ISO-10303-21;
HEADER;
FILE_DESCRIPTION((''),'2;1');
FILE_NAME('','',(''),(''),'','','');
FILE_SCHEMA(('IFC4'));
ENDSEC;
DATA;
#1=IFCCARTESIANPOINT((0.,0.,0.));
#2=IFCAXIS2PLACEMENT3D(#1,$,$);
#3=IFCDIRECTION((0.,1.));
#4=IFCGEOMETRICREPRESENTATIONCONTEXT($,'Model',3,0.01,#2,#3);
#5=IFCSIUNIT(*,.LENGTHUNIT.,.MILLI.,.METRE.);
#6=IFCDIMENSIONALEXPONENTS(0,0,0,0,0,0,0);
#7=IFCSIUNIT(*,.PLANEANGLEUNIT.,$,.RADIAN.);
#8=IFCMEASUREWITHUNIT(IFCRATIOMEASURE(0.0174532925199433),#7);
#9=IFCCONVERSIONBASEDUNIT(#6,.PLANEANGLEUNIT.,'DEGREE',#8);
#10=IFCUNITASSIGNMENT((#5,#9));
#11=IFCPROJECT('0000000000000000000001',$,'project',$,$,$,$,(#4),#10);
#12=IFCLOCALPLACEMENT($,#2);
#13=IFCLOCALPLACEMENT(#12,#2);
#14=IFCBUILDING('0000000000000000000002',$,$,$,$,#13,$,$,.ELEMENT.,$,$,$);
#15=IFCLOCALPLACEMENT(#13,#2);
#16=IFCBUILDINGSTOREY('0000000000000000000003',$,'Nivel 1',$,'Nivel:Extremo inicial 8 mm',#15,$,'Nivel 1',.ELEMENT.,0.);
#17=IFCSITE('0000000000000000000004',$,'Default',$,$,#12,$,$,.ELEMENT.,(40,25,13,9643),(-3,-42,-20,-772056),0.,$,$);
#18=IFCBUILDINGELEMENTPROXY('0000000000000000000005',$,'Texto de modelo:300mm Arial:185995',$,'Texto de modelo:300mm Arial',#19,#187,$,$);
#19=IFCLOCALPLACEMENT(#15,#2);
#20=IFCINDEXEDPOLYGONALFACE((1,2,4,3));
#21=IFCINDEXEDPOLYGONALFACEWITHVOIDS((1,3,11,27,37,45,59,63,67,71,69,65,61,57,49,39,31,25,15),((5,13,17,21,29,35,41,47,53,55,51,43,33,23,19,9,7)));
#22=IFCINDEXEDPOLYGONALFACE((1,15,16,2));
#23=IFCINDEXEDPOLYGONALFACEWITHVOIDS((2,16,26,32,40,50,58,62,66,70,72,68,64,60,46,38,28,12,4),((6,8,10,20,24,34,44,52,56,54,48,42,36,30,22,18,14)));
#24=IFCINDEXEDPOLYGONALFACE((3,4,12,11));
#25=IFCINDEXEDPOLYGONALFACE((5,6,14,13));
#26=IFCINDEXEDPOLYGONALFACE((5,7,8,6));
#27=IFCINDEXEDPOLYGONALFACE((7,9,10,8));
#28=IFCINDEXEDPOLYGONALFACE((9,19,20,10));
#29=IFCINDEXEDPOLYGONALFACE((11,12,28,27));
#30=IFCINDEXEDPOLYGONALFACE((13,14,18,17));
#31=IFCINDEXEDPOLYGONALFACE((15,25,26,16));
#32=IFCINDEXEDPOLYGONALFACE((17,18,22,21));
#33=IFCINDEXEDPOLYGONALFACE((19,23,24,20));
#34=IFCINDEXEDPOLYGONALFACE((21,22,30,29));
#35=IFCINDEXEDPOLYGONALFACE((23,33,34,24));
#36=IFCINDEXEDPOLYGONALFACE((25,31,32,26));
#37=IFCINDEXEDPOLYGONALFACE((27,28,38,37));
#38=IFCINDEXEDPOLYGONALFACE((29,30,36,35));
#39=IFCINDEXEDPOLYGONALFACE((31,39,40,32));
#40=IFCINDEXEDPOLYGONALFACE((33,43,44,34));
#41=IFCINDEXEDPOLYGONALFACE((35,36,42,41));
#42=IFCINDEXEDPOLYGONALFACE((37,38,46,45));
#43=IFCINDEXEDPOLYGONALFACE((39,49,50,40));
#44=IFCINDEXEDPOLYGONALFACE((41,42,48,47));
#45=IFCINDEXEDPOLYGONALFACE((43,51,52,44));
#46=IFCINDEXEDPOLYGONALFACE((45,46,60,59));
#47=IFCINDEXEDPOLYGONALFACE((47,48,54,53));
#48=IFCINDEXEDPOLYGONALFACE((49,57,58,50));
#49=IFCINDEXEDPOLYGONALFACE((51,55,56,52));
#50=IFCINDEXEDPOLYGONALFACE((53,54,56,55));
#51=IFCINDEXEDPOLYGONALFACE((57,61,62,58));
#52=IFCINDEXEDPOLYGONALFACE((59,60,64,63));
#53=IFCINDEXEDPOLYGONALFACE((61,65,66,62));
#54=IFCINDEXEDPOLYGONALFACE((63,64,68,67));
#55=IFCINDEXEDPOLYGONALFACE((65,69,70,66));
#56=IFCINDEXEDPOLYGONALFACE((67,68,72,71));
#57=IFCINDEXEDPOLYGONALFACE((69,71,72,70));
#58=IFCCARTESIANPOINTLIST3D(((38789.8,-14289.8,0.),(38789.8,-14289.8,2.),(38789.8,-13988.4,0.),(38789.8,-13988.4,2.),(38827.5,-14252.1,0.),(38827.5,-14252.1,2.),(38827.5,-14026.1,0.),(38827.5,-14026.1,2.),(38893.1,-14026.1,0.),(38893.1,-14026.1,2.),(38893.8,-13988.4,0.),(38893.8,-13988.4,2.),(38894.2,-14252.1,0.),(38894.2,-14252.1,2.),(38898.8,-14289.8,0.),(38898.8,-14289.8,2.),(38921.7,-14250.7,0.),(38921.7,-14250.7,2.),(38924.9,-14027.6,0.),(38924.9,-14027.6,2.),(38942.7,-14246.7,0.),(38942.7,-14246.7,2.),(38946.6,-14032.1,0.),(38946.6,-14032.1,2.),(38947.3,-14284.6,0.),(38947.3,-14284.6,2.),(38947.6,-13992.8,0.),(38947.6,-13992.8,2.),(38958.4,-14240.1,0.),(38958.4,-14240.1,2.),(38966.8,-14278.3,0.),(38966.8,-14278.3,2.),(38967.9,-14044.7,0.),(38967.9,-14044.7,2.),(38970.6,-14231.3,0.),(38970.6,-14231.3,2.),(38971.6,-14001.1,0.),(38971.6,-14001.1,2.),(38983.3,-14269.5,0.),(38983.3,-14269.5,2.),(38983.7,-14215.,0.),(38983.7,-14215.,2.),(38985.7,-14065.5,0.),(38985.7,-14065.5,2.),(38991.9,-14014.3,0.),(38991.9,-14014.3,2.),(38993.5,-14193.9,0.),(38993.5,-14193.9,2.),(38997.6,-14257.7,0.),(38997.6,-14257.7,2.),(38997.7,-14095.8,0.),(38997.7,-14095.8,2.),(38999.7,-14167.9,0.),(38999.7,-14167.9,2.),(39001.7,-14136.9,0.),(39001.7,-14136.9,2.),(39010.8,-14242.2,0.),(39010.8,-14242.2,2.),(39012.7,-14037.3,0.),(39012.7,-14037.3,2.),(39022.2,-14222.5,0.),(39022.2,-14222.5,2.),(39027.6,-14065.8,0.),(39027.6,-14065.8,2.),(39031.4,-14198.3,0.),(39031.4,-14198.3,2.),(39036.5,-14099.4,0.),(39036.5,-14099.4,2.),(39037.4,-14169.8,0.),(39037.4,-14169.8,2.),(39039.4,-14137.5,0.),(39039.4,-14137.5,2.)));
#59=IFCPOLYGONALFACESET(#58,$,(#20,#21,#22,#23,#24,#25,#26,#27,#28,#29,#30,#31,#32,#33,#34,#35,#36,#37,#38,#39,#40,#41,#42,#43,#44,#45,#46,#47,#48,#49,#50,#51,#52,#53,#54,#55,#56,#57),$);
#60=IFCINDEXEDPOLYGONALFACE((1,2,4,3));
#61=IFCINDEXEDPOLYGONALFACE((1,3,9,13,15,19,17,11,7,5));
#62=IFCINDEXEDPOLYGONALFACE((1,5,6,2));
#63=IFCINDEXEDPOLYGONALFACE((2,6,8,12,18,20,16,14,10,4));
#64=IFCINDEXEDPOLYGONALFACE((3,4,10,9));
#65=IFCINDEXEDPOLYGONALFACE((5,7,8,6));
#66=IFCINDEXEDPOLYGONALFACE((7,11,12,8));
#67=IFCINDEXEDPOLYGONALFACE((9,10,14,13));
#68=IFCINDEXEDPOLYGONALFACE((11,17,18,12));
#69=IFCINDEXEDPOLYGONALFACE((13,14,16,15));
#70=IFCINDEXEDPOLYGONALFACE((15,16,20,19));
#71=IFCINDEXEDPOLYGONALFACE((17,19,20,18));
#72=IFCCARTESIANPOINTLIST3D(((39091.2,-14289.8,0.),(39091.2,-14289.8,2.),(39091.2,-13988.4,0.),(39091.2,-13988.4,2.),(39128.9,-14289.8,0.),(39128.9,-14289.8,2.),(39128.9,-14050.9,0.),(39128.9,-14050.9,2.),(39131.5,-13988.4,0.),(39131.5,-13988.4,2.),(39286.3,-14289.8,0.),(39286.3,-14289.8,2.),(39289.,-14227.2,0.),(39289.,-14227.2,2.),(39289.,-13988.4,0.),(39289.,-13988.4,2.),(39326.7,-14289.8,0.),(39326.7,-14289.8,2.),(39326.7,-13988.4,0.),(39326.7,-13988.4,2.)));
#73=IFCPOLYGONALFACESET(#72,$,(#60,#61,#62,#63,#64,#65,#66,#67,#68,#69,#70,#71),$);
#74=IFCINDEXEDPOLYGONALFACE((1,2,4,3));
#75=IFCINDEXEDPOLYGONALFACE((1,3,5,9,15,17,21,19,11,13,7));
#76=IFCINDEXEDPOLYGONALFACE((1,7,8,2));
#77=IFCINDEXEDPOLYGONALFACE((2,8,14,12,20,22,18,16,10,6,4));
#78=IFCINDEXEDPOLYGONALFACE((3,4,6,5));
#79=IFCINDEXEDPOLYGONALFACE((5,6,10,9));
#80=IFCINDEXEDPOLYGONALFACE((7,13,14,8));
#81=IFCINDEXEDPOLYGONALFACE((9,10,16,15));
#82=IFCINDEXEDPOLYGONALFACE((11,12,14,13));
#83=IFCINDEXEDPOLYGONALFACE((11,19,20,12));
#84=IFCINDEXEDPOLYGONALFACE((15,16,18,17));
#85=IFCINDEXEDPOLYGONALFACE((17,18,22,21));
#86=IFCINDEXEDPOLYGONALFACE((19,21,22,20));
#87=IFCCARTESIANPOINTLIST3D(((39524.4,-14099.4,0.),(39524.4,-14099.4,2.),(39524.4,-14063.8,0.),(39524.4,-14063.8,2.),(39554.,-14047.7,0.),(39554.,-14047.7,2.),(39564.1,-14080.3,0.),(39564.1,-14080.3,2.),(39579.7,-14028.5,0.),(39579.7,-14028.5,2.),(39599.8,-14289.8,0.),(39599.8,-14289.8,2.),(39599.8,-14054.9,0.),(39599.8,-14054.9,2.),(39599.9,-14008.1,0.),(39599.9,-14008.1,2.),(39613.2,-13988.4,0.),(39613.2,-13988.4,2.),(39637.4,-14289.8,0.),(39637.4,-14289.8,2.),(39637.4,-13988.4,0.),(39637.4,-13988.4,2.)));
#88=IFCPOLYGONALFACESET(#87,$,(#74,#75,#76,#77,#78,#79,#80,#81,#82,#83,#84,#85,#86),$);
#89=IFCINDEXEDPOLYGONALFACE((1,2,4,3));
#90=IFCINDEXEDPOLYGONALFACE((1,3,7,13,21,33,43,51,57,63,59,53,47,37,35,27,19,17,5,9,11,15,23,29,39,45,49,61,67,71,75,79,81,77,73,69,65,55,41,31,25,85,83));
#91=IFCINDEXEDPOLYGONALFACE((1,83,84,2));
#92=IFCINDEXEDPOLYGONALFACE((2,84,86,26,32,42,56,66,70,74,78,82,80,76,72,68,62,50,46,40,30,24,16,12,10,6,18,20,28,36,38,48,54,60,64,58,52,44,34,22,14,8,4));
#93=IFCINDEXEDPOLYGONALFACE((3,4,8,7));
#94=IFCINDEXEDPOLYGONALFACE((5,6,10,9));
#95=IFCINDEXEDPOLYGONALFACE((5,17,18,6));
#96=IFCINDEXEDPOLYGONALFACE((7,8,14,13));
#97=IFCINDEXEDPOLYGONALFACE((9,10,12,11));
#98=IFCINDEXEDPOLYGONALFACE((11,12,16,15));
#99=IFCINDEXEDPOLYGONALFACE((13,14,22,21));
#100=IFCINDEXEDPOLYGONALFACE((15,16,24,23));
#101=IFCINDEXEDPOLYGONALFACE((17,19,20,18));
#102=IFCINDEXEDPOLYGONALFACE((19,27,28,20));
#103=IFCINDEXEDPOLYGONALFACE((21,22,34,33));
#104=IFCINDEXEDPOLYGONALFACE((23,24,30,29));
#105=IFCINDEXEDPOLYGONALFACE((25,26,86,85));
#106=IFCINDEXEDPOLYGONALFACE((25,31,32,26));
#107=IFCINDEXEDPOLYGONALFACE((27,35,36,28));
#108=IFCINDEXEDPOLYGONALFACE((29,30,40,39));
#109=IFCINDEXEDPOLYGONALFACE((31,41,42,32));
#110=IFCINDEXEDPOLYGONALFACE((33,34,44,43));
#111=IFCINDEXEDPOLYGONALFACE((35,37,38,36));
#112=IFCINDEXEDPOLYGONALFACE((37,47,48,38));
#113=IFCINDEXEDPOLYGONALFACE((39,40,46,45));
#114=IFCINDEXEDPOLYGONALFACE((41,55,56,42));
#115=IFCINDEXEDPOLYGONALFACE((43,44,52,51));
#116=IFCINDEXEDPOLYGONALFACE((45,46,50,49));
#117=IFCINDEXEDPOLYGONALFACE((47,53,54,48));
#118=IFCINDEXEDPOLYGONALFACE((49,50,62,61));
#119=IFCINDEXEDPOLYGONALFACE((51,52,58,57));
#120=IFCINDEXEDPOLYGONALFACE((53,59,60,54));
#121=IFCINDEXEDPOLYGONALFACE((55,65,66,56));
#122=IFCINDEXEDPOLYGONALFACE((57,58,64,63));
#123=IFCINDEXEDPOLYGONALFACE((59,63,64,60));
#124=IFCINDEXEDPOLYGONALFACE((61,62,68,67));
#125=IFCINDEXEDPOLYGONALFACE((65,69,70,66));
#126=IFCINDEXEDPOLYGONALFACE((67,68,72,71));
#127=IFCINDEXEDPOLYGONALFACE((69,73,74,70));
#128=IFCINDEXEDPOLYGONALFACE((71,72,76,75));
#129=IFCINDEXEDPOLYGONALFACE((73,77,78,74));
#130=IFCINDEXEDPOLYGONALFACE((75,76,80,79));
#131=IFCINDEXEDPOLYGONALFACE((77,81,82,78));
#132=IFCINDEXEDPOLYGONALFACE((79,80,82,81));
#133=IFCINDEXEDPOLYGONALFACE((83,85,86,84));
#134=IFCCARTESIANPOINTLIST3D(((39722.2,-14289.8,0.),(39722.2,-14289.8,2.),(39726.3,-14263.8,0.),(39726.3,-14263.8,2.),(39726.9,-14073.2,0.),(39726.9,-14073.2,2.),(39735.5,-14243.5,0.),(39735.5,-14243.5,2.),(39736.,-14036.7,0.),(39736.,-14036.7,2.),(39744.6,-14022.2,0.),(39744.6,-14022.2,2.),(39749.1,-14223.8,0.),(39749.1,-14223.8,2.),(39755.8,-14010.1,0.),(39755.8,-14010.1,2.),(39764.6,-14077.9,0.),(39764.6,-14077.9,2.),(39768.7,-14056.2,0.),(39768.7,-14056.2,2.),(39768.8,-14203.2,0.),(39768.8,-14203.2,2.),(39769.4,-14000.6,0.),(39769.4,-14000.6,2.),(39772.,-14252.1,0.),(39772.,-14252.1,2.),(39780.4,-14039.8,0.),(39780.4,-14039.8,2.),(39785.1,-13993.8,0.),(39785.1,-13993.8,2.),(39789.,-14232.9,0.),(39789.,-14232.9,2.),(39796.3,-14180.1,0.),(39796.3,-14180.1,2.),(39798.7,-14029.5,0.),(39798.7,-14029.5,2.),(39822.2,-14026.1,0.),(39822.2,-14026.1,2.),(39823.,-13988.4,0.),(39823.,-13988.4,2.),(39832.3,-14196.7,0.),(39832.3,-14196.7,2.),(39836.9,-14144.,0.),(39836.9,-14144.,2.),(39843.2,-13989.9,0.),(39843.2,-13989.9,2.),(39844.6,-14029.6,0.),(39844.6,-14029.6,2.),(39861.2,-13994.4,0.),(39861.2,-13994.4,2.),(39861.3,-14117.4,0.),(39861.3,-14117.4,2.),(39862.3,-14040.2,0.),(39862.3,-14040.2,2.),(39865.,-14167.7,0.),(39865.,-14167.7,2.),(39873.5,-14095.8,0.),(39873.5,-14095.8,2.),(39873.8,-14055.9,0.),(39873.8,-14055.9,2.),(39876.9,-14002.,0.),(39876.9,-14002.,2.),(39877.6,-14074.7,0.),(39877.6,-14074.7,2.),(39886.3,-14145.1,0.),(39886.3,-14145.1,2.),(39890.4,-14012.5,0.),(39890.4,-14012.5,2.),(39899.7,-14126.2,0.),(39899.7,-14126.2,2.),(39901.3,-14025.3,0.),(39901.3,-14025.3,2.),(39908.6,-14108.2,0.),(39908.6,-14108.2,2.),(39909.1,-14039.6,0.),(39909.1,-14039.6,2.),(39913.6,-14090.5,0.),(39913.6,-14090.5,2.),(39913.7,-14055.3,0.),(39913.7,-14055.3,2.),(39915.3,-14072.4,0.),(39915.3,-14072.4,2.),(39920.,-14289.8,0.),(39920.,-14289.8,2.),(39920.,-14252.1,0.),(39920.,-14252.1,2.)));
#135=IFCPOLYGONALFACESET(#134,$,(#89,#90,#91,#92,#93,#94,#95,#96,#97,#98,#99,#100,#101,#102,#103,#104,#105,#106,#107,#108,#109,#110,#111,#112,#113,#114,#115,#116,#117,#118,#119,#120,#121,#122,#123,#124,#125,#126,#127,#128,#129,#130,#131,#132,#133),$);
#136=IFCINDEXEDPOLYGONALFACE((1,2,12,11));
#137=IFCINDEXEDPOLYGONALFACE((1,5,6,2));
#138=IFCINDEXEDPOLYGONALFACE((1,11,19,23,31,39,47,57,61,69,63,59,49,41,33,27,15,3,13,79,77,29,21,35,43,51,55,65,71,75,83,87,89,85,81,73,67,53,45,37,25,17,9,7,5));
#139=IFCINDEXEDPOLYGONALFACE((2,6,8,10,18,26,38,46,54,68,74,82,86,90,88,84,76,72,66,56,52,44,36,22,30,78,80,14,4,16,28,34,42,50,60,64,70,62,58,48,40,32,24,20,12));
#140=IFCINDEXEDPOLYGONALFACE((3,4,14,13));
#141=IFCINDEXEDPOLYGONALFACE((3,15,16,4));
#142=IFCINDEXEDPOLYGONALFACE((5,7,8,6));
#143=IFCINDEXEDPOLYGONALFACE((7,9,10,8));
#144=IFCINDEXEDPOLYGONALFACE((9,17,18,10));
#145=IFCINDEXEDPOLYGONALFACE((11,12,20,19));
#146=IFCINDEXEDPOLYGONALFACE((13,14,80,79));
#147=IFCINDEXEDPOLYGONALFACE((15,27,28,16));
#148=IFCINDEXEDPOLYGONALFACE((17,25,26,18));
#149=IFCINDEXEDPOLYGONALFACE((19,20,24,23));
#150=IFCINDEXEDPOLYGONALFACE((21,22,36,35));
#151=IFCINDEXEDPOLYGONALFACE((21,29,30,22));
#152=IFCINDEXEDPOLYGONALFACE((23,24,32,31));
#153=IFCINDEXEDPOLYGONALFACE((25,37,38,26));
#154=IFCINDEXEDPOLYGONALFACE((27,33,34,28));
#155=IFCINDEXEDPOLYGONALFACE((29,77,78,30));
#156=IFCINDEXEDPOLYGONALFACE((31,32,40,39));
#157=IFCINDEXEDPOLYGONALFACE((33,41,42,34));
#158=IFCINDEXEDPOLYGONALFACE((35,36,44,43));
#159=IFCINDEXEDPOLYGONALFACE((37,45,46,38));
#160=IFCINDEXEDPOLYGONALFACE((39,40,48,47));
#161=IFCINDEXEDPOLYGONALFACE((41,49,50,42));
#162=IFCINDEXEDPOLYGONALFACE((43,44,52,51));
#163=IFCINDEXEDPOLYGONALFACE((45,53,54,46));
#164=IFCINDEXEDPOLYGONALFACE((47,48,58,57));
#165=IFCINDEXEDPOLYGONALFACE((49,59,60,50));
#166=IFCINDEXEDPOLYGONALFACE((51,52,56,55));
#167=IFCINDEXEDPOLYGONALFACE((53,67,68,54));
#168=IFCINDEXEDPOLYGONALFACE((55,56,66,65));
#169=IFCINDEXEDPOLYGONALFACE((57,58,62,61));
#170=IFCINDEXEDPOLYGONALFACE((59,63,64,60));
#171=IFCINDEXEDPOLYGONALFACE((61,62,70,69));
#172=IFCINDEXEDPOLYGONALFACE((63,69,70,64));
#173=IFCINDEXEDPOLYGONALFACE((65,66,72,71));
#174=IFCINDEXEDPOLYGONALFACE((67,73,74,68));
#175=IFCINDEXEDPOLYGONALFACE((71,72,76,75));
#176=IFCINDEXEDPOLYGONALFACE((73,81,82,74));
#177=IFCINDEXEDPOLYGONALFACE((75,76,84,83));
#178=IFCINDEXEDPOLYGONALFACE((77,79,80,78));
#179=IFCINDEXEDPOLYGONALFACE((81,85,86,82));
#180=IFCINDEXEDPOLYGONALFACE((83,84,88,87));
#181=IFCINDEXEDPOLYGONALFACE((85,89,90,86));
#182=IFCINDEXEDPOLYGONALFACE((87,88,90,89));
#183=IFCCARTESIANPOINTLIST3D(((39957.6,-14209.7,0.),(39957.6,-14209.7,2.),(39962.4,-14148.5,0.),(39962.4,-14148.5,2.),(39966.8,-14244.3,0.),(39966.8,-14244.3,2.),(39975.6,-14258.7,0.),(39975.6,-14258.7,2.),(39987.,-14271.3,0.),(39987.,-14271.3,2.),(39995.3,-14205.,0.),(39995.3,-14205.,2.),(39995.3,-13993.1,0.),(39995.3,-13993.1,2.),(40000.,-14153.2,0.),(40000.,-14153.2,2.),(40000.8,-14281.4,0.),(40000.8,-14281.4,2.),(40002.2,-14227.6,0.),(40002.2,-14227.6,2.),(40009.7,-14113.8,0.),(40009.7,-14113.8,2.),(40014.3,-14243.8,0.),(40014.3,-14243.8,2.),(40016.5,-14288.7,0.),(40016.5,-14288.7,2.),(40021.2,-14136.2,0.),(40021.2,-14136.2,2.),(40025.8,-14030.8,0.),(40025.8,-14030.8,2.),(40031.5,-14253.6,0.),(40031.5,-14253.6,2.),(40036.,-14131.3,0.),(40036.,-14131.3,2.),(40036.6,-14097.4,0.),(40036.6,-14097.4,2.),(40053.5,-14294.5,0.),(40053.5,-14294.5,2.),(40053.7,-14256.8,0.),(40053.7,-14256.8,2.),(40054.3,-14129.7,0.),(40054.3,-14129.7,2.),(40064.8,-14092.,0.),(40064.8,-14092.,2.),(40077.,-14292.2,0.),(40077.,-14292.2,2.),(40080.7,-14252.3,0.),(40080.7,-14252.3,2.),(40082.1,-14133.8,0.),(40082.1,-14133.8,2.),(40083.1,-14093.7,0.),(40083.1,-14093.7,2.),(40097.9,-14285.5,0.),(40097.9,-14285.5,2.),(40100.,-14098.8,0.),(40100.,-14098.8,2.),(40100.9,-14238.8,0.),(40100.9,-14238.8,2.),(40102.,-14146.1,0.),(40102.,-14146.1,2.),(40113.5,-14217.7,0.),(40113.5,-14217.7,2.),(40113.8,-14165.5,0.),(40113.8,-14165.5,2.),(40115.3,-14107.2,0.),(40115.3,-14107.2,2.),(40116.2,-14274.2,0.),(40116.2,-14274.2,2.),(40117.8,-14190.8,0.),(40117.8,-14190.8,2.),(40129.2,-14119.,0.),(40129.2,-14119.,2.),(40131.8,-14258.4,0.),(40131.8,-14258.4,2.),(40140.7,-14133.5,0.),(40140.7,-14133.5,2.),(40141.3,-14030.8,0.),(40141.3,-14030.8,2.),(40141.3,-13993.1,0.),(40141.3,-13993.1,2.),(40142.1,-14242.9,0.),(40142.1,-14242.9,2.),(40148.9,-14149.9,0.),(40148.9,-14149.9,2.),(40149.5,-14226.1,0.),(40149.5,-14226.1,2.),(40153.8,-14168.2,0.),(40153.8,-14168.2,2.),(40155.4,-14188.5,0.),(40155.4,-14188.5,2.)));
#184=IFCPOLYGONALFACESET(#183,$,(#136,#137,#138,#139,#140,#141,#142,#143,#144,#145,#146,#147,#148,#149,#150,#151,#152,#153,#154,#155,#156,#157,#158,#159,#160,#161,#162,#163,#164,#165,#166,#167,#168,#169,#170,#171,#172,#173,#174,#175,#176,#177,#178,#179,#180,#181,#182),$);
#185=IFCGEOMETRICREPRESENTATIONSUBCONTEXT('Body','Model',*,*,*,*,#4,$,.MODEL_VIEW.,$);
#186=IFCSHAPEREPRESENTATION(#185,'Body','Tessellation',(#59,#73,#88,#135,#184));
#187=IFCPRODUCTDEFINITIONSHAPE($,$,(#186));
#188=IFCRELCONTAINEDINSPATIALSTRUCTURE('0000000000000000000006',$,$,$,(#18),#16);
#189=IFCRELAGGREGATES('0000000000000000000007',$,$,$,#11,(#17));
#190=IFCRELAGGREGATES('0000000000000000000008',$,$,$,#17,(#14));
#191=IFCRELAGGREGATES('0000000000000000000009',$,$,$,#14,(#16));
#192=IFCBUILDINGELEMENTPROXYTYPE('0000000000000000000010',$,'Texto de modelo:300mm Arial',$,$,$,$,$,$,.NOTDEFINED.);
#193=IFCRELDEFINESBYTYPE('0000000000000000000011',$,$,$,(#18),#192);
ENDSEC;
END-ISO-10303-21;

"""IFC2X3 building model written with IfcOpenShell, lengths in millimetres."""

from ifc_helpers import new_model, entity, si_unit, converted_unit, direction, frame, origin, place, context, subcontext, project, spatial, polyline, outline, extrude, type_object, element, save


model = new_model("IFC2X3")

# Units and contexts
model_context = context("Model", 3, precision=0.01, world=origin(), true_north=direction((0.0, 1.0)))
body_context = subcontext(model_context, "Body", "Model", "MODEL_VIEW")
ifc_project = project(units=[si_unit("LENGTHUNIT", "METRE", prefix="MILLI"), converted_unit("PLANEANGLEUNIT", "DEGREE", entity("IfcRatioMeasure", 0.0174532925199433), si_unit("PLANEANGLEUNIT", "RADIAN"), dimensions=[0, 0, 0, 0, 0, 0, 0])], contexts=[model_context])

# Site, building, storey
site_placement = place(None, origin())
site = spatial("IfcSite", under=ifc_project, at=site_placement, Name="Default", CompositionType="ELEMENT", RefLatitude=(40, 25, 13, 9643), RefLongitude=(-3, -42, -20, -772056), RefElevation=0.0)
building_placement = place(site_placement, origin())
building = spatial("IfcBuilding", under=site, at=building_placement, CompositionType="ELEMENT")
storey_placement = place(building_placement, origin())
storey = spatial("IfcBuildingStorey", under=building, at=storey_placement, Name="Nivel 1", ObjectType="Nivel:Extremo inicial 8 mm", LongName="Nivel 1", CompositionType="ELEMENT", Elevation=0.0)

# Building element proxy
building_element_proxy_type_1 = type_object("IfcBuildingElementProxyType", Name="Texto de modelo:300mm Arial", PredefinedType="NOTDEFINED")
proxy_1_placement = place(storey_placement, frame((38789.8, -14294.5, 0.0)))
element("IfcBuildingElementProxy", 1, at=proxy_1_placement, inside=storey, type_object=building_element_proxy_type_1, Name="Texto de modelo:300mm Arial:185995", ObjectType="Texto de modelo:300mm Arial", context=body_context, shape_type="SweptSolid", body=[
    extrude(outline(polyline([(-178.4, -141.0), (-69.4, -141.0), (-21.0, -135.8), (-1.4, -129.5), (15.0, -120.7), (29.4, -108.9), (42.6, -93.4), (54.0, -73.7), (63.2, -49.5), (69.2, -21.0), (71.2, 11.3), (68.2, 49.4), (59.3, 83.0), (44.5, 111.5), (23.7, 134.5), (3.4, 147.7), (-20.6, 156.1), (-74.4, 160.4), (-178.4, 160.4), (-178.4, -141.0)]), holes=[polyline([(-140.7, -103.3), (-140.7, 122.7), (-75.1, 122.7), (-43.3, 121.2), (-21.7, 116.7), (-0.4, 104.1), (17.4, 83.3), (29.5, 53.0), (33.5, 11.9), (31.5, -19.1), (25.3, -45.1), (15.5, -66.2), (2.4, -82.5), (-9.8, -91.3), (-25.6, -97.9), (-46.5, -101.9), (-74.1, -103.3), (-140.7, -103.3)])]), frame((178.4, 145.7, 0.0)), (0.0, 0.0, 1.0), 2.0),
    extrude(outline(polyline([(-117.7, -150.7), (-80.1, -150.7), (-80.1, 88.1), (77.4, -150.7), (117.7, -150.7), (117.7, 150.7), (80.1, 150.7), (80.1, -88.1), (-77.4, 150.7), (-117.7, 150.7), (-117.7, -150.7)])), frame((419.1, 155.4, 0.0)), (0.0, 0.0, 1.0), 2.0),
    extrude(outline(polyline([(-204.4, -52.5), (97.0, -52.5), (97.0, -28.2), (77.2, -14.9), (56.9, 5.3), (37.7, 30.9), (21.6, 60.5), (-14.0, 60.5), (5.0, 20.8), (30.4, -14.9), (-204.4, -14.9), (-204.4, -52.5)])), frame((795.1, 209.1, 0.0), z_axis=(0.0, 0.0, 1.0), x_axis=(0.0, 1.0, 0.0)), (0.0, 0.0, 1.0), 2.0),
    extrude(outline(polyline([(-91.6, -150.5), (-91.6, -188.2), (106.2, -188.2), (102.1, -162.2), (92.9, -141.9), (79.3, -122.2), (59.6, -101.6), (32.1, -78.5), (-8.5, -42.4), (-32.9, -15.8), (-45.1, 5.8), (-49.2, 26.9), (-45.4, 45.8), (-33.9, 61.4), (-16.2, 72.0), (6.2, 75.5), (29.7, 72.1), (48.0, 61.8), (59.7, 45.4), (63.8, 23.7), (101.5, 28.4), (92.4, 64.9), (83.8, 79.4), (72.6, 91.5), (59.0, 101.0), (43.3, 107.8), (5.4, 113.2), (-14.8, 111.7), (-32.8, 107.2), (-48.5, 99.6), (-62.0, 89.1), (-72.9, 76.3), (-80.7, 62.0), (-85.3, 46.3), (-86.9, 29.2), (-85.2, 11.2), (-80.2, -6.5), (-71.3, -24.6), (-57.9, -43.5), (-36.6, -66.1), (-3.9, -95.1), (39.4, -131.3), (56.4, -150.5), (-91.6, -150.5)])), frame((1038.6, 192.9, 0.0), z_axis=(0.0, 0.0, -1.0), x_axis=(-1.0, 0.0, 0.0)), (0.0, 0.0, -1.0), 2.0),
    extrude(outline(polyline([(1.4, -113.1), (37.2, -113.1), (53.4, -108.4), (68.5, -100.5), (81.8, -89.8), (92.9, -76.5), (108.0, -42.2), (111.8, -18.9), (110.6, 3.0), (104.4, 23.5), (93.2, 42.7), (80.9, 56.7), (66.6, 68.1), (31.7, 83.5), (11.7, 87.1), (-7.3, 87.1), (-25.2, 83.4), (-42.2, 76.0), (-57.1, 65.7), (-69.2, 53.0), (-78.5, 38.0), (-84.8, 20.7), (-86.8, -7.9), (-77.9, -38.1), (-154.0, -1.2), (-124.3, 110.4), (-160.7, 120.1), (-198.2, -21.0), (-56.5, -92.8), (-42.3, -57.6), (-53.3, -32.8), (-54.2, -17.2), (-51.1, 0.9), (-40.0, 26.8), (-23.0, 42.8), (-1.2, 49.2), (24.3, 46.5), (49.2, 35.5), (66.3, 17.9), (74.2, -5.1), (71.6, -32.4), (62.8, -53.0), (48.9, -67.1), (30.2, -74.6), (6.6, -75.5), (1.4, -113.1)])), frame((1276.7, 115.2, 0.0), z_axis=(0.0, 0.0, 1.0), x_axis=(0.256974, -0.966418, 0.0)), (0.0, 0.0, 1.0), 2.0),
])

save(model, "model.ifc")
